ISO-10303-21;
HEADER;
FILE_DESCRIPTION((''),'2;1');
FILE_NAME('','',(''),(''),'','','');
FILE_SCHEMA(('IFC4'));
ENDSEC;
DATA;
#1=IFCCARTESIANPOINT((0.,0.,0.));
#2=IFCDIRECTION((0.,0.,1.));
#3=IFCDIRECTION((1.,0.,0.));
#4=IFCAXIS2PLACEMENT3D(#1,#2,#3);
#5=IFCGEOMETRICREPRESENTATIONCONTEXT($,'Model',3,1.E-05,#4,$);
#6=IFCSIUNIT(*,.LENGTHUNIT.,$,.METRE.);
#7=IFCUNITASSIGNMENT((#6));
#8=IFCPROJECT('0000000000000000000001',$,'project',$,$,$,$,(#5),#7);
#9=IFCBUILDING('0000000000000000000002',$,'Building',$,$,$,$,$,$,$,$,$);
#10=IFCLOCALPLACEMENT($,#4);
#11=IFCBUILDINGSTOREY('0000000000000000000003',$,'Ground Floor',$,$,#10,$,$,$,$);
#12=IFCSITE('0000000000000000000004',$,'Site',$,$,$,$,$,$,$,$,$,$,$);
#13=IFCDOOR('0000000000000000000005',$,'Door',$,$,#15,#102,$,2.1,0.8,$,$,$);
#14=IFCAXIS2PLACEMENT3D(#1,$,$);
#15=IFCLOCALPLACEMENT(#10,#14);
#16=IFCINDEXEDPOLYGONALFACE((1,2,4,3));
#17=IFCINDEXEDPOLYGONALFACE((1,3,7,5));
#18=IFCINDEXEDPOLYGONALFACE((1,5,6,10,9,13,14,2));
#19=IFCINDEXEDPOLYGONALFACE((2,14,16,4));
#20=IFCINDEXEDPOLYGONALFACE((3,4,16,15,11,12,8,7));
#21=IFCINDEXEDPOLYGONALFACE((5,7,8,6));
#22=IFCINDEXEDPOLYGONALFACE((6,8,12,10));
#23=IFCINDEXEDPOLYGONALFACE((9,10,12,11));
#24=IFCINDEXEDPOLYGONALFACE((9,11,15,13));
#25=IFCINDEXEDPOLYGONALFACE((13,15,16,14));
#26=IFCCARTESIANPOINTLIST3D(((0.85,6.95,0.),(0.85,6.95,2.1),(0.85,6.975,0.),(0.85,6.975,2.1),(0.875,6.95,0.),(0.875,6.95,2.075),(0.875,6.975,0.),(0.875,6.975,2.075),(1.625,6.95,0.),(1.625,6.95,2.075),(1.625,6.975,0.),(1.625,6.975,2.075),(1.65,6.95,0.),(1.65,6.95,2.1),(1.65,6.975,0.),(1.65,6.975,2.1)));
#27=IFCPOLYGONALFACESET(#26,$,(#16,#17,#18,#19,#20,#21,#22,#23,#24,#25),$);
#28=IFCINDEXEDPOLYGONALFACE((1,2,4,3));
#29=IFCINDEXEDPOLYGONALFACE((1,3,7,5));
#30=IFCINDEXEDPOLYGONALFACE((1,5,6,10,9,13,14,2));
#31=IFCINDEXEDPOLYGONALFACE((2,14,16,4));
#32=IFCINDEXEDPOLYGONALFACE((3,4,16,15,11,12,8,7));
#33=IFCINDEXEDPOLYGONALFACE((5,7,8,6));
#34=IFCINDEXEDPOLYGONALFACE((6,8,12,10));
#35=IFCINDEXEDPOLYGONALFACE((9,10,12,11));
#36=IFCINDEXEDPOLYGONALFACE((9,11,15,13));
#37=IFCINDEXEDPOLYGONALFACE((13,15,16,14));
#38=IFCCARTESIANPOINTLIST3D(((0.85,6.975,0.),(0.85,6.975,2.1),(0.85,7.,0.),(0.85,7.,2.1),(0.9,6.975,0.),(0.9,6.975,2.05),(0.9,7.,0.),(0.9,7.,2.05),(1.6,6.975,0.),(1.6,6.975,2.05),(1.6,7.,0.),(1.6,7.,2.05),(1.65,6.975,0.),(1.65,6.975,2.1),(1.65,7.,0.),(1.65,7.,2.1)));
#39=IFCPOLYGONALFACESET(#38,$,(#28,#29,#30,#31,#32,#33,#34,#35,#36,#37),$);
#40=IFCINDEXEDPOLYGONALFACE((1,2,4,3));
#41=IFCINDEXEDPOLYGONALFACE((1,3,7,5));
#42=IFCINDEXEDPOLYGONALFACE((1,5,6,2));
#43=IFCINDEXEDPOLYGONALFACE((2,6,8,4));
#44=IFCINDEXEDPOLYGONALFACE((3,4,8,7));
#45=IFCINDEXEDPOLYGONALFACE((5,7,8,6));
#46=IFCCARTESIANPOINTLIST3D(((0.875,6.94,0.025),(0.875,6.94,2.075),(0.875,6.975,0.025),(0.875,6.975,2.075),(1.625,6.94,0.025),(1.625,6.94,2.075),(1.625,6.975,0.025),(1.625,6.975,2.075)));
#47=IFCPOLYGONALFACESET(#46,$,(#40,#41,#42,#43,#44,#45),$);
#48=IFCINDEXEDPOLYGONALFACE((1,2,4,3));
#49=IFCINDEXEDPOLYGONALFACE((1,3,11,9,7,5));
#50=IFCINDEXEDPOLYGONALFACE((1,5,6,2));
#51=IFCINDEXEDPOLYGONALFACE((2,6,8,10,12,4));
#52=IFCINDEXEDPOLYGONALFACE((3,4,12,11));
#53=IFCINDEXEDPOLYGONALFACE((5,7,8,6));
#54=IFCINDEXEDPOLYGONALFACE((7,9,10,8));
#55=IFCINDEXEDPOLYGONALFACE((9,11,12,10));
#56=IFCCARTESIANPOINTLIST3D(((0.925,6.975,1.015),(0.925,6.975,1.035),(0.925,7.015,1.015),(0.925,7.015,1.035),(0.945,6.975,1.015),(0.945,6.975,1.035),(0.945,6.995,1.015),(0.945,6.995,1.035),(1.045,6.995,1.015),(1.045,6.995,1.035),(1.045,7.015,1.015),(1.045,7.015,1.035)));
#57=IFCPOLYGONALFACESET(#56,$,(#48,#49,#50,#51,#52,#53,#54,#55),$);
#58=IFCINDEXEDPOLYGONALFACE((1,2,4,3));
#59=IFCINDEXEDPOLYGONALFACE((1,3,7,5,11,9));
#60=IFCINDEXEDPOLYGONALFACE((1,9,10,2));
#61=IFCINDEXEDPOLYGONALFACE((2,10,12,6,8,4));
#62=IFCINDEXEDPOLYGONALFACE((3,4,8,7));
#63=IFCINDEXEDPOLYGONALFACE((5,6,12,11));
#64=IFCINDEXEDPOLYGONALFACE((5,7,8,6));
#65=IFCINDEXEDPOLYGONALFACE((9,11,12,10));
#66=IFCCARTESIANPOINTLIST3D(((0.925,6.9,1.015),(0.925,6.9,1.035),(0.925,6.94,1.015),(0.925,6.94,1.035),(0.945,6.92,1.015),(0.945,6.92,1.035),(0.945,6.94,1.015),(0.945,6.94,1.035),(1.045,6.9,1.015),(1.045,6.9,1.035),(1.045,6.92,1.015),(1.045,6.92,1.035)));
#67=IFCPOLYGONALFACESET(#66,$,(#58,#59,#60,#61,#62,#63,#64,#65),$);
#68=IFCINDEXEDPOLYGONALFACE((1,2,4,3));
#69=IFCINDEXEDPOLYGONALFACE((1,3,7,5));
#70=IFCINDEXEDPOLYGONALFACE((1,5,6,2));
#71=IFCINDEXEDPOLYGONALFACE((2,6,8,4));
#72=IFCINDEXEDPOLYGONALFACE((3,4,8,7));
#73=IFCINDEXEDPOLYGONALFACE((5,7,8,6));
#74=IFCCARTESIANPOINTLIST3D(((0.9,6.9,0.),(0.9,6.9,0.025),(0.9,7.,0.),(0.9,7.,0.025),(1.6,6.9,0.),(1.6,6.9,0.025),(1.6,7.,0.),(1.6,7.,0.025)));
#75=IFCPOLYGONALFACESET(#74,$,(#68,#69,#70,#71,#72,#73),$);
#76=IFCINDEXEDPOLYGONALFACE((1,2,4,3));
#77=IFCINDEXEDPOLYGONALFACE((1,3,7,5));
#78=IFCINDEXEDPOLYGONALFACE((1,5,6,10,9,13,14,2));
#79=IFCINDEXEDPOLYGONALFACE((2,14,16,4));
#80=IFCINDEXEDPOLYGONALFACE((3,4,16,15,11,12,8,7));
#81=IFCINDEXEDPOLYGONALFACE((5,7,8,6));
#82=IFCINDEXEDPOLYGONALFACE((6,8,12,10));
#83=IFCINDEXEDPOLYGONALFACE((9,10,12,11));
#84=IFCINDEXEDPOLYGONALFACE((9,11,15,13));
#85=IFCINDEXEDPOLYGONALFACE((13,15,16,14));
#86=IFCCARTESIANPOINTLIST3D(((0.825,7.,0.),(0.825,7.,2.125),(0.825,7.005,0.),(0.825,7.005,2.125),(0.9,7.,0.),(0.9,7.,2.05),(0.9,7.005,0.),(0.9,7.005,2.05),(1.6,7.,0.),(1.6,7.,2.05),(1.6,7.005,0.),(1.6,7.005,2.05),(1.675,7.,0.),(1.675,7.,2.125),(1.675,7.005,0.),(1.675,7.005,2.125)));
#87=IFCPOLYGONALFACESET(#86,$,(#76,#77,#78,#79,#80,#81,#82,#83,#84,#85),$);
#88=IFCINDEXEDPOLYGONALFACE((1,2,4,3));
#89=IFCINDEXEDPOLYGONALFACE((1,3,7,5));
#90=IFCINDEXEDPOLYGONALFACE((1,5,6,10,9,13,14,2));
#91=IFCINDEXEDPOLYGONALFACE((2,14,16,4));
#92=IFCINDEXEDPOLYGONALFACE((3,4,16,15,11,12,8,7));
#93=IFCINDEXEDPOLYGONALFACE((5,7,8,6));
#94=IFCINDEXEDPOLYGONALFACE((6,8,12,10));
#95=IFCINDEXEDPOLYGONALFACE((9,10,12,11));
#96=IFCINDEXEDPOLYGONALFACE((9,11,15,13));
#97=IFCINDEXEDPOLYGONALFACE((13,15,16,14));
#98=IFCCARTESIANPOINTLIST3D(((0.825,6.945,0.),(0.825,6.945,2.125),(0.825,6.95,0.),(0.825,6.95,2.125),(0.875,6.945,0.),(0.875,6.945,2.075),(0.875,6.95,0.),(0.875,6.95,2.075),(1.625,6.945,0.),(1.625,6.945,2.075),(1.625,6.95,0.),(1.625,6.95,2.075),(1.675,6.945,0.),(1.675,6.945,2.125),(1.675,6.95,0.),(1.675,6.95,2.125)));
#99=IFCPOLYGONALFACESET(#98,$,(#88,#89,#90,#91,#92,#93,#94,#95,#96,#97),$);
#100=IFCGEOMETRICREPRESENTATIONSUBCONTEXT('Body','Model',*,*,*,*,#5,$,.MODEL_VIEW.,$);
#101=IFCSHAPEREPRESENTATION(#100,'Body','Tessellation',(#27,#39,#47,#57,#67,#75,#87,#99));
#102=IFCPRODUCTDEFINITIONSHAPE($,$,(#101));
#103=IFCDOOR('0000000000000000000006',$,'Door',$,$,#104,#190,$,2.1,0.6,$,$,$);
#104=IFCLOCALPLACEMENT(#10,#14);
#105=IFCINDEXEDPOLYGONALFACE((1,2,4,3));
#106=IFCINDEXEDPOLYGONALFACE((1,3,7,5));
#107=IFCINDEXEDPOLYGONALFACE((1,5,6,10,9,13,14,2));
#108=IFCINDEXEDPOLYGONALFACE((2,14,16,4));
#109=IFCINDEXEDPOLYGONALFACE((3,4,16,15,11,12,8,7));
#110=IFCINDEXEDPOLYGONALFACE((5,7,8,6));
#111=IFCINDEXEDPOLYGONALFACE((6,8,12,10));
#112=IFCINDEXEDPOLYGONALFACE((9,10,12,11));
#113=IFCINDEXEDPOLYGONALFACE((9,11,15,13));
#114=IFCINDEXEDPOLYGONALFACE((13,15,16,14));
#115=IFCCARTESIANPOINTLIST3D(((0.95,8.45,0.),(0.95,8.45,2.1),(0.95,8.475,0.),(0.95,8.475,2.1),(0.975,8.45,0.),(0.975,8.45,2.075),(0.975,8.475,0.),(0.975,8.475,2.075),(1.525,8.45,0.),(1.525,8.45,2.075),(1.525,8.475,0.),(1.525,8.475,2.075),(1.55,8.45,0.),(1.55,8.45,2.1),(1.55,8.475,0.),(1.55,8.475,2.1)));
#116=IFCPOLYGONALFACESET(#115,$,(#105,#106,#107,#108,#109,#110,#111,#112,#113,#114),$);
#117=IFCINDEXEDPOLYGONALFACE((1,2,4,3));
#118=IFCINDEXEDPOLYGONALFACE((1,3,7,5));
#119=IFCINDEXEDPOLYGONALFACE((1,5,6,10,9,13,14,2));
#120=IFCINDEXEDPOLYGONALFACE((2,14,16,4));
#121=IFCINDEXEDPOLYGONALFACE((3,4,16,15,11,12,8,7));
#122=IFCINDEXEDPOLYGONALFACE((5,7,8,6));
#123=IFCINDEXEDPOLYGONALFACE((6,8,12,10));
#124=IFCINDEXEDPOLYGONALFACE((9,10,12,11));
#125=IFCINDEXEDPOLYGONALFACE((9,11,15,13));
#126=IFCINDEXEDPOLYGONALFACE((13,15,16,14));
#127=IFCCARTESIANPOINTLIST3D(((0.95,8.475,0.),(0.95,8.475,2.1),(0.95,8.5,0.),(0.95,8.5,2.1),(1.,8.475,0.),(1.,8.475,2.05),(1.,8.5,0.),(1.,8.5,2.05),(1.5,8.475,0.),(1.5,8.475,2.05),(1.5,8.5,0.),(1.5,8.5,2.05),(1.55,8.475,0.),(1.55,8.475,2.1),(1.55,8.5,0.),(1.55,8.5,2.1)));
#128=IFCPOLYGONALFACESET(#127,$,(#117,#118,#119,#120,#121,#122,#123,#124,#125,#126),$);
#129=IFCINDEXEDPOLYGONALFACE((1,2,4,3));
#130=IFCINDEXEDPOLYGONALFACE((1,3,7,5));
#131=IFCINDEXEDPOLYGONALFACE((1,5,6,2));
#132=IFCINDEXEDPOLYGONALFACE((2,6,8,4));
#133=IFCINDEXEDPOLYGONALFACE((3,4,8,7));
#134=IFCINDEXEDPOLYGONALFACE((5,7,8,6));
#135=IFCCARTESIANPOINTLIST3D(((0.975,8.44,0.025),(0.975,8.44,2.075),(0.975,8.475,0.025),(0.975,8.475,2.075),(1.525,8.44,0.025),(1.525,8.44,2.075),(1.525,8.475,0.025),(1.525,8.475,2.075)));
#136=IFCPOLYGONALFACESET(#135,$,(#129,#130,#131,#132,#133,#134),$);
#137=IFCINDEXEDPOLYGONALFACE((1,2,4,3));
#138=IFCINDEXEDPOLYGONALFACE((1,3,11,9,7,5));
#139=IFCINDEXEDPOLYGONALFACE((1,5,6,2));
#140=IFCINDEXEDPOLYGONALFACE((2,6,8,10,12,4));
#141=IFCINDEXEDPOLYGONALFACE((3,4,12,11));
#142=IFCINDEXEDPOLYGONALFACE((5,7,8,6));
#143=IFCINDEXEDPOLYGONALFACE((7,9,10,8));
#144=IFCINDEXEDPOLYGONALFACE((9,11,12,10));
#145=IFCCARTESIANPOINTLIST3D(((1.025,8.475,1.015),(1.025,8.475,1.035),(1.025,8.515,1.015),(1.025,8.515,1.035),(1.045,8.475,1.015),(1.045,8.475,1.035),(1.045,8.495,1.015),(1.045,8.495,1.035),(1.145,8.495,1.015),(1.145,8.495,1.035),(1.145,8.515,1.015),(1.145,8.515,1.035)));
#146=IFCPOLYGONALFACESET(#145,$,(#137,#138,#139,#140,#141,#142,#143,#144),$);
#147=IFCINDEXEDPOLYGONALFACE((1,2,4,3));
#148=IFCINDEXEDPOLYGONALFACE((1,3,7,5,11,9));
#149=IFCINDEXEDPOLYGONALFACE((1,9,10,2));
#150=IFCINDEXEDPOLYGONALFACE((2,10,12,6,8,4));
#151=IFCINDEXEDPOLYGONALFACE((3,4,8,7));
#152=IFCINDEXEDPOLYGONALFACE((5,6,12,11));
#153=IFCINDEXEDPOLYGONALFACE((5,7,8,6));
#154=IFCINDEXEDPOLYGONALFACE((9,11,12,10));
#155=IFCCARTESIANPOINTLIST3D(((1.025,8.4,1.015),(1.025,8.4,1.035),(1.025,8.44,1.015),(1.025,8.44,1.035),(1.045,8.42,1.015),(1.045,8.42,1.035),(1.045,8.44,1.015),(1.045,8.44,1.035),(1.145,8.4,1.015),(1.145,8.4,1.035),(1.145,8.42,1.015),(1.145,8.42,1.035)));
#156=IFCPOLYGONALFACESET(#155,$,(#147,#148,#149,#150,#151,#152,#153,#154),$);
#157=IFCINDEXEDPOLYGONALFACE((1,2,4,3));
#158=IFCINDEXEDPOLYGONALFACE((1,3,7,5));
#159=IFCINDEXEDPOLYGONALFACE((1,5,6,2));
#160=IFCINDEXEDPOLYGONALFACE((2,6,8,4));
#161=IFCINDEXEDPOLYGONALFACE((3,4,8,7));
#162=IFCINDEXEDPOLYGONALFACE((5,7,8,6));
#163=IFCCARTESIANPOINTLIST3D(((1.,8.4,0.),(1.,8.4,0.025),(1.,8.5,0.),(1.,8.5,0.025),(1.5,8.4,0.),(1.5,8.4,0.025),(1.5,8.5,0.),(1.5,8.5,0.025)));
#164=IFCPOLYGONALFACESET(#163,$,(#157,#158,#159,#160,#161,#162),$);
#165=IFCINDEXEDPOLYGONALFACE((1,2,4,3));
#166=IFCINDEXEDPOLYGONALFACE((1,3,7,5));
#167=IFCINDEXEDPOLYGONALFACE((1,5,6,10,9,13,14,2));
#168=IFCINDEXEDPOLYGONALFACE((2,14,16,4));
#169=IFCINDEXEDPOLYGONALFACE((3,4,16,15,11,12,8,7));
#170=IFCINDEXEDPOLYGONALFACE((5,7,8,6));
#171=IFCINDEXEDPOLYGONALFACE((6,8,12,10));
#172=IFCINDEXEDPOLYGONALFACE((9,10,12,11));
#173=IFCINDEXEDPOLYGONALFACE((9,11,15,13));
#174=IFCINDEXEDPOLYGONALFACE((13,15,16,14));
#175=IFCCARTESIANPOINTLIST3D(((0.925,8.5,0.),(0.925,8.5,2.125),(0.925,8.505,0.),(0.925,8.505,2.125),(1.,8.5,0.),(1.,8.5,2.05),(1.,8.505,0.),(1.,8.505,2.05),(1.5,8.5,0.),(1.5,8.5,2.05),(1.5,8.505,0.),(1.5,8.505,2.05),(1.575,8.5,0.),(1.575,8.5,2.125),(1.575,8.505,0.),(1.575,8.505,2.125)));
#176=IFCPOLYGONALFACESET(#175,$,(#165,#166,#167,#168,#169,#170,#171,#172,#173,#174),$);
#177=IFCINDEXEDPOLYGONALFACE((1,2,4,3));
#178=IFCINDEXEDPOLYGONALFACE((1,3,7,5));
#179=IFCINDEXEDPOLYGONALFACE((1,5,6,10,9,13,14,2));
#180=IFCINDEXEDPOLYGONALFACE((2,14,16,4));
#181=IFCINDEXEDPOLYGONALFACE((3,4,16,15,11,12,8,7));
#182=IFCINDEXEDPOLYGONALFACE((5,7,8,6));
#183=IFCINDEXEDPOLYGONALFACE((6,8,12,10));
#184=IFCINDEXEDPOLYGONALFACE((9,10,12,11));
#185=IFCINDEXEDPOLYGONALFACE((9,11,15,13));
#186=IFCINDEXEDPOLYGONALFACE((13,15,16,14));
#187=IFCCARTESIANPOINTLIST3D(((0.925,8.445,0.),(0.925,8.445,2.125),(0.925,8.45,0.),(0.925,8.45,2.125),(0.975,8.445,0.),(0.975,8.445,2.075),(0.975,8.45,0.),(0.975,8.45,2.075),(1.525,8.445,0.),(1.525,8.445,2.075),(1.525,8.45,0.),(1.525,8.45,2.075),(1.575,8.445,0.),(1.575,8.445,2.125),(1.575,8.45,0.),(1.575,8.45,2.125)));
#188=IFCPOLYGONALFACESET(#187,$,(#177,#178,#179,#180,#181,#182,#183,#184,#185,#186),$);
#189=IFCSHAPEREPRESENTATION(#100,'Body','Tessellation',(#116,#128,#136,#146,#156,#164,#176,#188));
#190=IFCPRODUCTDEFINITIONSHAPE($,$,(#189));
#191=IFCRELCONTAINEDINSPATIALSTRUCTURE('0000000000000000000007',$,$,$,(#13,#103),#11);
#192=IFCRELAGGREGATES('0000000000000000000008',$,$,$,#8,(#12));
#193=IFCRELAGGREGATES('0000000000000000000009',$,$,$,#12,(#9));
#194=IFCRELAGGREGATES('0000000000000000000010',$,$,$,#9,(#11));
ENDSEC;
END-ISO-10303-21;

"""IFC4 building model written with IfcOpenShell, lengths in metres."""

from ifc_helpers import new_model, si_unit, frame, origin_with_axes, place, context, subcontext, project, spatial, line, indexed_curve, outline, extrude, element, save


model = new_model("IFC4")

# Units and contexts
model_context = context("Model", 3, precision=1e-05, world=origin_with_axes())
body_context = subcontext(model_context, "Body", "Model", "MODEL_VIEW")
ifc_project = project(units=[si_unit("LENGTHUNIT", "METRE")], contexts=[model_context])

# Site, building, storey
site = spatial("IfcSite", under=ifc_project, Name="Site")
building = spatial("IfcBuilding", under=site, Name="Building")
storey_placement = place(None, origin_with_axes())
storey = spatial("IfcBuildingStorey", under=building, at=storey_placement, Name="Ground Floor")

# Doors
door_1_placement = place(storey_placement, frame((1.65, 7.0, 0.0), z_axis=(0.0, 0.0, 1.0), x_axis=(-1.0, 0.0, 0.0)))
element("IfcDoor", 1, at=door_1_placement, inside=storey, Name="Door", OverallHeight=2.1, OverallWidth=0.8, context=body_context, shape_type="SweptSolid", body=[
    extrude(outline(indexed_curve([(0.0, 0.0), (0.0, 2.1), (0.8, 2.1), (0.8, 0.0), (0.775, 0.0), (0.775, 2.075), (0.025, 2.075), (0.025, 0.0)], segments=[line(1, 2, 3, 4, 5, 6, 7, 8, 1)])), frame((0.0, 0.025, 0.0), z_axis=(0.0, -1.0, 0.0), x_axis=(1.0, 0.0, 0.0)), (0.0, 0.0, -1.0), 0.025),
    extrude(outline(indexed_curve([(0.0, 0.0), (0.0, 2.1), (0.8, 2.1), (0.8, 0.0), (0.75, 0.0), (0.75, 2.05), (0.05, 2.05), (0.05, 0.0)], segments=[line(1, 2, 3, 4, 5, 6, 7, 8, 1)])), frame((0.0, 0.0, 0.0), z_axis=(0.0, -1.0, 0.0), x_axis=(1.0, 0.0, 0.0)), (0.0, 0.0, -1.0), 0.025),
    extrude(outline(indexed_curve([(0.0, 0.0), (0.75, 0.0), (0.75, 0.035), (0.0, 0.035)], segments=[line(1, 2, 3, 4, 1)])), frame((0.025, 0.025, 0.025), z_axis=(0.0, 0.0, 1.0), x_axis=(1.0, 0.0, 0.0)), (0.0, 0.0, 1.0), 2.05),
    extrude(outline(indexed_curve([(0.0, 0.0), (0.0, -0.04), (-0.12, -0.04), (-0.12, -0.02), (-0.02, -0.02), (-0.02, 0.0)], segments=[line(1, 2, 3, 4, 5, 6, 1)])), frame((0.725, 0.025, 1.015), z_axis=(0.0, 0.0, 1.0), x_axis=(1.0, 0.0, 0.0)), (0.0, 0.0, 1.0), 0.02),
    extrude(outline(indexed_curve([(0.0, 0.0), (0.0, 0.04), (-0.12, 0.04), (-0.12, 0.02), (-0.02, 0.02), (-0.02, 0.0)], segments=[line(1, 2, 3, 4, 5, 6, 1)])), frame((0.725, 0.06, 1.015), z_axis=(0.0, 0.0, 1.0), x_axis=(1.0, 0.0, 0.0)), (0.0, 0.0, 1.0), 0.02),
    extrude(outline(indexed_curve([(0.0, 0.0), (0.7, 0.0), (0.7, 0.1), (0.0, 0.1)], segments=[line(1, 2, 3, 4, 1)])), frame((0.05, 0.0, 0.0), z_axis=(0.0, 0.0, 1.0), x_axis=(1.0, 0.0, 0.0)), (0.0, 0.0, 1.0), 0.025),
    extrude(outline(indexed_curve([(0.0, 0.0), (0.0, 2.125), (0.85, 2.125), (0.85, 0.0), (0.775, 0.0), (0.775, 2.05), (0.075, 2.05), (0.075, 0.0)], segments=[line(1, 2, 3, 4, 5, 6, 7, 8, 1)])), frame((-0.025, -0.005, 0.0), z_axis=(0.0, -1.0, 0.0), x_axis=(1.0, 0.0, 0.0)), (0.0, 0.0, -1.0), 0.005),
    extrude(outline(indexed_curve([(0.0, 0.0), (0.0, 2.125), (0.85, 2.125), (0.85, 0.0), (0.8, 0.0), (0.8, 2.075), (0.05, 2.075), (0.05, 0.0)], segments=[line(1, 2, 3, 4, 5, 6, 7, 8, 1)])), frame((-0.025, 0.05, 0.0), z_axis=(0.0, -1.0, 0.0), x_axis=(1.0, 0.0, 0.0)), (0.0, 0.0, -1.0), 0.005),
])
door_2_placement = place(storey_placement, frame((1.55, 8.5, 0.0), z_axis=(0.0, 0.0, 1.0), x_axis=(-1.0, 0.0, 0.0)))
element("IfcDoor", 2, at=door_2_placement, inside=storey, Name="Door", OverallHeight=2.1, OverallWidth=0.6, context=body_context, shape_type="SweptSolid", body=[
    extrude(outline(indexed_curve([(0.0, 0.0), (0.0, 2.1), (0.6, 2.1), (0.6, 0.0), (0.575, 0.0), (0.575, 2.075), (0.025, 2.075), (0.025, 0.0)], segments=[line(1, 2, 3, 4, 5, 6, 7, 8, 1)])), frame((0.0, 0.025, 0.0), z_axis=(0.0, -1.0, 0.0), x_axis=(1.0, 0.0, 0.0)), (0.0, 0.0, -1.0), 0.025),
    extrude(outline(indexed_curve([(0.0, 0.0), (0.0, 2.1), (0.6, 2.1), (0.6, 0.0), (0.55, 0.0), (0.55, 2.05), (0.05, 2.05), (0.05, 0.0)], segments=[line(1, 2, 3, 4, 5, 6, 7, 8, 1)])), frame((0.0, 0.0, 0.0), z_axis=(0.0, -1.0, 0.0), x_axis=(1.0, 0.0, 0.0)), (0.0, 0.0, -1.0), 0.025),
    extrude(outline(indexed_curve([(0.0, 0.0), (0.55, 0.0), (0.55, 0.035), (0.0, 0.035)], segments=[line(1, 2, 3, 4, 1)])), frame((0.025, 0.025, 0.025), z_axis=(0.0, 0.0, 1.0), x_axis=(1.0, 0.0, 0.0)), (0.0, 0.0, 1.0), 2.05),
    extrude(outline(indexed_curve([(0.0, 0.0), (0.0, -0.04), (-0.12, -0.04), (-0.12, -0.02), (-0.02, -0.02), (-0.02, 0.0)], segments=[line(1, 2, 3, 4, 5, 6, 1)])), frame((0.525, 0.025, 1.015), z_axis=(0.0, 0.0, 1.0), x_axis=(1.0, 0.0, 0.0)), (0.0, 0.0, 1.0), 0.02),
    extrude(outline(indexed_curve([(0.0, 0.0), (0.0, 0.04), (-0.12, 0.04), (-0.12, 0.02), (-0.02, 0.02), (-0.02, 0.0)], segments=[line(1, 2, 3, 4, 5, 6, 1)])), frame((0.525, 0.06, 1.015), z_axis=(0.0, 0.0, 1.0), x_axis=(1.0, 0.0, 0.0)), (0.0, 0.0, 1.0), 0.02),
    extrude(outline(indexed_curve([(0.0, 0.0), (0.5, 0.0), (0.5, 0.1), (0.0, 0.1)], segments=[line(1, 2, 3, 4, 1)])), frame((0.05, 0.0, 0.0), z_axis=(0.0, 0.0, 1.0), x_axis=(1.0, 0.0, 0.0)), (0.0, 0.0, 1.0), 0.025),
    extrude(outline(indexed_curve([(0.0, 0.0), (0.0, 2.125), (0.65, 2.125), (0.65, 0.0), (0.575, 0.0), (0.575, 2.05), (0.075, 2.05), (0.075, 0.0)], segments=[line(1, 2, 3, 4, 5, 6, 7, 8, 1)])), frame((-0.025, -0.005, 0.0), z_axis=(0.0, -1.0, 0.0), x_axis=(1.0, 0.0, 0.0)), (0.0, 0.0, -1.0), 0.005),
    extrude(outline(indexed_curve([(0.0, 0.0), (0.0, 2.125), (0.65, 2.125), (0.65, 0.0), (0.6, 0.0), (0.6, 2.075), (0.05, 2.075), (0.05, 0.0)], segments=[line(1, 2, 3, 4, 5, 6, 7, 8, 1)])), frame((-0.025, 0.05, 0.0), z_axis=(0.0, -1.0, 0.0), x_axis=(1.0, 0.0, 0.0)), (0.0, 0.0, -1.0), 0.005),
])

save(model, "model.ifc")
